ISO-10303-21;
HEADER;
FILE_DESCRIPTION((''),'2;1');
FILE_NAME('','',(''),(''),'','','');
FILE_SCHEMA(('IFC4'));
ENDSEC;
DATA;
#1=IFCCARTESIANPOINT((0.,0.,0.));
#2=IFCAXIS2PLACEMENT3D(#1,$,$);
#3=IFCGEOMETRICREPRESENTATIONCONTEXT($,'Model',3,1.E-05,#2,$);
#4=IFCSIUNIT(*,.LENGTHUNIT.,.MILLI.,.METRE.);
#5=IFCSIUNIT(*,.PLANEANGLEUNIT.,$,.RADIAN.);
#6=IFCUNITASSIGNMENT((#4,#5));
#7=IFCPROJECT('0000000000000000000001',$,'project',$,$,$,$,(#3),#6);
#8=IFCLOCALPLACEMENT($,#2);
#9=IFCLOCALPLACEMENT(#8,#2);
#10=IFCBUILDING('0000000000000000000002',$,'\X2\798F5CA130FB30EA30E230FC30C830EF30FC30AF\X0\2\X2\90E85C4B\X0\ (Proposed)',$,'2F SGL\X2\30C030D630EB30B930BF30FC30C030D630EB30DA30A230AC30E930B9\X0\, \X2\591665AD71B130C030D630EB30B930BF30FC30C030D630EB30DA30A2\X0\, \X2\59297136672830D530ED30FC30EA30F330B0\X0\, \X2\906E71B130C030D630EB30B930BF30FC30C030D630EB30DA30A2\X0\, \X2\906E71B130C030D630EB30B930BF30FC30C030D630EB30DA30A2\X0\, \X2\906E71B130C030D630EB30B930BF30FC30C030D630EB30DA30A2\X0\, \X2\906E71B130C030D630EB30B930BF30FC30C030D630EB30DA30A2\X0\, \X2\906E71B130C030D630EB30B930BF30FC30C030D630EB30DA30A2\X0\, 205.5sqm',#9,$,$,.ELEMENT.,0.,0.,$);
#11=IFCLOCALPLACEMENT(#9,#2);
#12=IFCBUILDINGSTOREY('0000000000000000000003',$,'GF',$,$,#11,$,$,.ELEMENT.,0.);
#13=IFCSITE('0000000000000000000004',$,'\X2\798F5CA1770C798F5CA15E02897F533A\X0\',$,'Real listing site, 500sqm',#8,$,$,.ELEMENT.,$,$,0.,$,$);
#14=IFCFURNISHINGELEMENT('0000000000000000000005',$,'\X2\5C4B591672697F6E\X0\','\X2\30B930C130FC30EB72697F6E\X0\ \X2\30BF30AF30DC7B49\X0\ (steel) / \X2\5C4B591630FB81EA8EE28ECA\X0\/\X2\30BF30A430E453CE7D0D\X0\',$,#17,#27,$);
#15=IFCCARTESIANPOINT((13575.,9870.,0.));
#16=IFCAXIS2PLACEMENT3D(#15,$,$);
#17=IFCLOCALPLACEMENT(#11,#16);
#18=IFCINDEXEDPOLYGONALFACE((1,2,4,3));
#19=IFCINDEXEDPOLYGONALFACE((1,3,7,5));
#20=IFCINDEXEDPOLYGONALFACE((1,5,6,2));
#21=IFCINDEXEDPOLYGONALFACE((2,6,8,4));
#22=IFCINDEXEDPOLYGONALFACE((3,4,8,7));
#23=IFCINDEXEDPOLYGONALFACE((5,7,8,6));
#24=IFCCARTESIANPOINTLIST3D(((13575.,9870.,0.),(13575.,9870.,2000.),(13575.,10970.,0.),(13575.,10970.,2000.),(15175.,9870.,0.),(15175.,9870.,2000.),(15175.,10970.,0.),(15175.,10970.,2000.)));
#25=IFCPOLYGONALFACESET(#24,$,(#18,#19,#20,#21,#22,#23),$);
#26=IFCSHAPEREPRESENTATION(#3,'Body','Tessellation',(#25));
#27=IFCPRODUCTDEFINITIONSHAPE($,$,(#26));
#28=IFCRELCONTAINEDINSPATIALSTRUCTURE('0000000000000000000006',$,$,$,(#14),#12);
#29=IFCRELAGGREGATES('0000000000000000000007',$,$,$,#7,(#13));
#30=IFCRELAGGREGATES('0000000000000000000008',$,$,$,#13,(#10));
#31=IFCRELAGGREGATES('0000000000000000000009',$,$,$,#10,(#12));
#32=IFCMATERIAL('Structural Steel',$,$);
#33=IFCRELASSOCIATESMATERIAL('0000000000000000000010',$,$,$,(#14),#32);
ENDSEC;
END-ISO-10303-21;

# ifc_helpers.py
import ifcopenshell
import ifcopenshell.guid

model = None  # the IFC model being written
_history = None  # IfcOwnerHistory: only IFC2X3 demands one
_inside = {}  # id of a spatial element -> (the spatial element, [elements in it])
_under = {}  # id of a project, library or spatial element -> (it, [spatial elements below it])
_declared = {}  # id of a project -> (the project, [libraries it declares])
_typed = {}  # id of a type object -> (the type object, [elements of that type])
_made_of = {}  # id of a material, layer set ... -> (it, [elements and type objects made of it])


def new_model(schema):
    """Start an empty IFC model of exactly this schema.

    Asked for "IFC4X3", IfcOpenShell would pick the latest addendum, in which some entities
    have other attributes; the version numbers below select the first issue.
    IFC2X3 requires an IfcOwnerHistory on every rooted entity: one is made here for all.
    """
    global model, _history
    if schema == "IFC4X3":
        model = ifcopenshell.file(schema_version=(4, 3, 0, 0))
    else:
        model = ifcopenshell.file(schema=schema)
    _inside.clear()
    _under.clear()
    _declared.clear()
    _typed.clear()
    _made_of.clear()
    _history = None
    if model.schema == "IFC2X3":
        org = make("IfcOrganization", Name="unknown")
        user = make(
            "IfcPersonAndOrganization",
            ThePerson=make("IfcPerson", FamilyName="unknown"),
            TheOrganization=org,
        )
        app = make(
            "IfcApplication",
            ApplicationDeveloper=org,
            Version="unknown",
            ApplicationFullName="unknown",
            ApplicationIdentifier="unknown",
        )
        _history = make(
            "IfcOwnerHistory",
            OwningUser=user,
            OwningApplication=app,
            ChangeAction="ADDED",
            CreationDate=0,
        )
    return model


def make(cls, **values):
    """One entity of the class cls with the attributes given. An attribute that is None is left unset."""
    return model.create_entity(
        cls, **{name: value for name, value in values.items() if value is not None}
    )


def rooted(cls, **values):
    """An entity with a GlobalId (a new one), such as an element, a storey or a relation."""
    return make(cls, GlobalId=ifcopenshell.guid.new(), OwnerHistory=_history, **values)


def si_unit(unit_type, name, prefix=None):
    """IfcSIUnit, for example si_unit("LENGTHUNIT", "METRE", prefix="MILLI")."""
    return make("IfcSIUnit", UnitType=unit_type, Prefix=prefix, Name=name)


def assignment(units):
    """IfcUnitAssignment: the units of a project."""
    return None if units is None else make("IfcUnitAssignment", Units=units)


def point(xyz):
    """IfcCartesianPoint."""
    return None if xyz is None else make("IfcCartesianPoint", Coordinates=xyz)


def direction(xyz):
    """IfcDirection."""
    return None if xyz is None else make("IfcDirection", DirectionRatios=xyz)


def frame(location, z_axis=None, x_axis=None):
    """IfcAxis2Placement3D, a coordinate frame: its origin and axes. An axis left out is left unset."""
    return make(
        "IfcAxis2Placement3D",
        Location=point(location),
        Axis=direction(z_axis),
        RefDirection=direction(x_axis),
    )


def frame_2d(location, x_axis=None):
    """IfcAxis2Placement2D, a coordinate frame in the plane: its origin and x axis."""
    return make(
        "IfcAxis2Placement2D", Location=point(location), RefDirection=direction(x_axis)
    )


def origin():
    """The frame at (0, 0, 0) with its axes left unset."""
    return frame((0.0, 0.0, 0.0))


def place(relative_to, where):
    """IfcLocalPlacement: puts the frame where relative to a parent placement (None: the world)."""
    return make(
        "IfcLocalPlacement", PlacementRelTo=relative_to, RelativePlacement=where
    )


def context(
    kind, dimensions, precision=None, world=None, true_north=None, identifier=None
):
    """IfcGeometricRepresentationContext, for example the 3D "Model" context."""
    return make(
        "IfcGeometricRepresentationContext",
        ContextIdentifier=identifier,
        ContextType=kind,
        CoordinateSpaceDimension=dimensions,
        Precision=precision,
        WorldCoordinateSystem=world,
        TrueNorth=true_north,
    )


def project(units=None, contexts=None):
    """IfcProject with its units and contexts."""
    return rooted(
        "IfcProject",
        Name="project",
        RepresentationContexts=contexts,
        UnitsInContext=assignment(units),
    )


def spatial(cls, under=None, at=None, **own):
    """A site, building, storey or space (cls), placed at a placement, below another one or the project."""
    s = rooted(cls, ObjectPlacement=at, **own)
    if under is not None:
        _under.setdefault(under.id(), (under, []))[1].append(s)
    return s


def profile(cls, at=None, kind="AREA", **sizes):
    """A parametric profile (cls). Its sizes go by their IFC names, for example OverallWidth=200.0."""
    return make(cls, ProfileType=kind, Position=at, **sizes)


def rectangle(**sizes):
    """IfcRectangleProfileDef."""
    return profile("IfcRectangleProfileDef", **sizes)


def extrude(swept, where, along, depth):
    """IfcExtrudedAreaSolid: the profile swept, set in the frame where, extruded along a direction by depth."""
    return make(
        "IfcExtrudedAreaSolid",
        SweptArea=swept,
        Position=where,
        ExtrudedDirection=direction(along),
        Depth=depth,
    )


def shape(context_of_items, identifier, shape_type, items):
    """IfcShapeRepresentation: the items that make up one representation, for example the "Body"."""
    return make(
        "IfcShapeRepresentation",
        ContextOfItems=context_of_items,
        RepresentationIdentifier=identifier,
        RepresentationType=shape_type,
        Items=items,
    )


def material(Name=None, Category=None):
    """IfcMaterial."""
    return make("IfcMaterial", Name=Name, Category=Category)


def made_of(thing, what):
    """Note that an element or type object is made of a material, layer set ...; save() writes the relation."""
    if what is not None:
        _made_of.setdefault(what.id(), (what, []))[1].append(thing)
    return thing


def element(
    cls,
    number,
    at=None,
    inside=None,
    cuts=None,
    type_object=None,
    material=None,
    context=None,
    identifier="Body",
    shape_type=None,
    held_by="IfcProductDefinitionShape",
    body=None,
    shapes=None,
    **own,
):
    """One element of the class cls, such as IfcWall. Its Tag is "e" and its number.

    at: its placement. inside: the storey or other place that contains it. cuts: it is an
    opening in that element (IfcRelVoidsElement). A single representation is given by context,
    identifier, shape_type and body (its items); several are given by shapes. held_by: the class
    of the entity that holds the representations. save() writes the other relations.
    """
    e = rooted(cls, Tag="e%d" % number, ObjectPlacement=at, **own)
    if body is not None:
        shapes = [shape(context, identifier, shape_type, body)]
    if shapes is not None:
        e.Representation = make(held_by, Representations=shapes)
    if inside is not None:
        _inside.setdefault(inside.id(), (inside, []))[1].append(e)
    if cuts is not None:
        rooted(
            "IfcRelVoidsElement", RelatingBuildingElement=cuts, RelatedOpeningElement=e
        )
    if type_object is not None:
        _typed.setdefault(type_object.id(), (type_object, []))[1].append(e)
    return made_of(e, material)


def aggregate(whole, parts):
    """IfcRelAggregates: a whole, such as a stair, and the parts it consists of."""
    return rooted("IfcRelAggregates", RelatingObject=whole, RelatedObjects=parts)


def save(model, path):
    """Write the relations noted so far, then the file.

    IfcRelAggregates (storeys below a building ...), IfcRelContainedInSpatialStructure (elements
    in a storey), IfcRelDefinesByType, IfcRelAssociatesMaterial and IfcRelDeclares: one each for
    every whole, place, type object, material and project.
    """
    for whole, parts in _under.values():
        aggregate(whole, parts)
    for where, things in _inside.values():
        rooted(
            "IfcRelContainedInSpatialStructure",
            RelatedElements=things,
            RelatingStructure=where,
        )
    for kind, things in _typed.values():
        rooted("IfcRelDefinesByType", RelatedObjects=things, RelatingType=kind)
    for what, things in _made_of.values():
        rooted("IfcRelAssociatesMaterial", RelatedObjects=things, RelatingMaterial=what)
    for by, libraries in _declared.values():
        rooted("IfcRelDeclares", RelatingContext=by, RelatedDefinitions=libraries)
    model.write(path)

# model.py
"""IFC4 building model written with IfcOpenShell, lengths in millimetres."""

from ifc_helpers import new_model, si_unit, frame, frame_2d, origin, place, context, project, spatial, rectangle, extrude, material, element, save


model = new_model("IFC4")

# Units and contexts
model_context = context("Model", 3, precision=1e-05, world=origin())
ifc_project = project(units=[si_unit("LENGTHUNIT", "METRE", prefix="MILLI"), si_unit("PLANEANGLEUNIT", "RADIAN")], contexts=[model_context])

# Site, building, storey
site_placement = place(None, origin())
site = spatial("IfcSite", under=ifc_project, at=site_placement, Name="福岡県福岡市西区", ObjectType="Real listing site, 500sqm", CompositionType="ELEMENT", RefElevation=0.0)
building_placement = place(site_placement, origin())
building = spatial("IfcBuilding", under=site, at=building_placement, Name="福岡・リモートワーク2部屋 (Proposed)", ObjectType="2F SGLダブルスターダブルペアガラス, 外断熱ダブルスターダブルペア, 天然木フローリング, 遮熱ダブルスターダブルペア, 遮熱ダブルスターダブルペア, 遮熱ダブルスターダブルペア, 遮熱ダブルスターダブルペア, 遮熱ダブルスターダブルペア, 205.5sqm", CompositionType="ELEMENT", ElevationOfRefHeight=0.0, ElevationOfTerrain=0.0)
storey_placement = place(building_placement, origin())
storey = spatial("IfcBuildingStorey", under=building, at=storey_placement, Name="GF", CompositionType="ELEMENT", Elevation=0.0)

# Shared definitions
ifc_material_1 = material(Name="Structural Steel")

# Furnishing element
furnishing_1_placement = place(storey_placement, frame((13575.0, 9870.0, 0.0)))
element("IfcFurnishingElement", 1, at=furnishing_1_placement, inside=storey, material=ifc_material_1, Name="屋外物置", Description="スチール物置 タクボ等 (steel) / 屋外・自転車/タイヤ収納", context=model_context, shape_type="SweptSolid", body=[
    extrude(rectangle(XDim=1600.0, YDim=1100.0, at=frame_2d((800.0, 550.0))), frame((13575.0, 9870.0, 0.0)), (0.0, 0.0, 1.0), 2000.0),
])

save(model, "model.ifc")
